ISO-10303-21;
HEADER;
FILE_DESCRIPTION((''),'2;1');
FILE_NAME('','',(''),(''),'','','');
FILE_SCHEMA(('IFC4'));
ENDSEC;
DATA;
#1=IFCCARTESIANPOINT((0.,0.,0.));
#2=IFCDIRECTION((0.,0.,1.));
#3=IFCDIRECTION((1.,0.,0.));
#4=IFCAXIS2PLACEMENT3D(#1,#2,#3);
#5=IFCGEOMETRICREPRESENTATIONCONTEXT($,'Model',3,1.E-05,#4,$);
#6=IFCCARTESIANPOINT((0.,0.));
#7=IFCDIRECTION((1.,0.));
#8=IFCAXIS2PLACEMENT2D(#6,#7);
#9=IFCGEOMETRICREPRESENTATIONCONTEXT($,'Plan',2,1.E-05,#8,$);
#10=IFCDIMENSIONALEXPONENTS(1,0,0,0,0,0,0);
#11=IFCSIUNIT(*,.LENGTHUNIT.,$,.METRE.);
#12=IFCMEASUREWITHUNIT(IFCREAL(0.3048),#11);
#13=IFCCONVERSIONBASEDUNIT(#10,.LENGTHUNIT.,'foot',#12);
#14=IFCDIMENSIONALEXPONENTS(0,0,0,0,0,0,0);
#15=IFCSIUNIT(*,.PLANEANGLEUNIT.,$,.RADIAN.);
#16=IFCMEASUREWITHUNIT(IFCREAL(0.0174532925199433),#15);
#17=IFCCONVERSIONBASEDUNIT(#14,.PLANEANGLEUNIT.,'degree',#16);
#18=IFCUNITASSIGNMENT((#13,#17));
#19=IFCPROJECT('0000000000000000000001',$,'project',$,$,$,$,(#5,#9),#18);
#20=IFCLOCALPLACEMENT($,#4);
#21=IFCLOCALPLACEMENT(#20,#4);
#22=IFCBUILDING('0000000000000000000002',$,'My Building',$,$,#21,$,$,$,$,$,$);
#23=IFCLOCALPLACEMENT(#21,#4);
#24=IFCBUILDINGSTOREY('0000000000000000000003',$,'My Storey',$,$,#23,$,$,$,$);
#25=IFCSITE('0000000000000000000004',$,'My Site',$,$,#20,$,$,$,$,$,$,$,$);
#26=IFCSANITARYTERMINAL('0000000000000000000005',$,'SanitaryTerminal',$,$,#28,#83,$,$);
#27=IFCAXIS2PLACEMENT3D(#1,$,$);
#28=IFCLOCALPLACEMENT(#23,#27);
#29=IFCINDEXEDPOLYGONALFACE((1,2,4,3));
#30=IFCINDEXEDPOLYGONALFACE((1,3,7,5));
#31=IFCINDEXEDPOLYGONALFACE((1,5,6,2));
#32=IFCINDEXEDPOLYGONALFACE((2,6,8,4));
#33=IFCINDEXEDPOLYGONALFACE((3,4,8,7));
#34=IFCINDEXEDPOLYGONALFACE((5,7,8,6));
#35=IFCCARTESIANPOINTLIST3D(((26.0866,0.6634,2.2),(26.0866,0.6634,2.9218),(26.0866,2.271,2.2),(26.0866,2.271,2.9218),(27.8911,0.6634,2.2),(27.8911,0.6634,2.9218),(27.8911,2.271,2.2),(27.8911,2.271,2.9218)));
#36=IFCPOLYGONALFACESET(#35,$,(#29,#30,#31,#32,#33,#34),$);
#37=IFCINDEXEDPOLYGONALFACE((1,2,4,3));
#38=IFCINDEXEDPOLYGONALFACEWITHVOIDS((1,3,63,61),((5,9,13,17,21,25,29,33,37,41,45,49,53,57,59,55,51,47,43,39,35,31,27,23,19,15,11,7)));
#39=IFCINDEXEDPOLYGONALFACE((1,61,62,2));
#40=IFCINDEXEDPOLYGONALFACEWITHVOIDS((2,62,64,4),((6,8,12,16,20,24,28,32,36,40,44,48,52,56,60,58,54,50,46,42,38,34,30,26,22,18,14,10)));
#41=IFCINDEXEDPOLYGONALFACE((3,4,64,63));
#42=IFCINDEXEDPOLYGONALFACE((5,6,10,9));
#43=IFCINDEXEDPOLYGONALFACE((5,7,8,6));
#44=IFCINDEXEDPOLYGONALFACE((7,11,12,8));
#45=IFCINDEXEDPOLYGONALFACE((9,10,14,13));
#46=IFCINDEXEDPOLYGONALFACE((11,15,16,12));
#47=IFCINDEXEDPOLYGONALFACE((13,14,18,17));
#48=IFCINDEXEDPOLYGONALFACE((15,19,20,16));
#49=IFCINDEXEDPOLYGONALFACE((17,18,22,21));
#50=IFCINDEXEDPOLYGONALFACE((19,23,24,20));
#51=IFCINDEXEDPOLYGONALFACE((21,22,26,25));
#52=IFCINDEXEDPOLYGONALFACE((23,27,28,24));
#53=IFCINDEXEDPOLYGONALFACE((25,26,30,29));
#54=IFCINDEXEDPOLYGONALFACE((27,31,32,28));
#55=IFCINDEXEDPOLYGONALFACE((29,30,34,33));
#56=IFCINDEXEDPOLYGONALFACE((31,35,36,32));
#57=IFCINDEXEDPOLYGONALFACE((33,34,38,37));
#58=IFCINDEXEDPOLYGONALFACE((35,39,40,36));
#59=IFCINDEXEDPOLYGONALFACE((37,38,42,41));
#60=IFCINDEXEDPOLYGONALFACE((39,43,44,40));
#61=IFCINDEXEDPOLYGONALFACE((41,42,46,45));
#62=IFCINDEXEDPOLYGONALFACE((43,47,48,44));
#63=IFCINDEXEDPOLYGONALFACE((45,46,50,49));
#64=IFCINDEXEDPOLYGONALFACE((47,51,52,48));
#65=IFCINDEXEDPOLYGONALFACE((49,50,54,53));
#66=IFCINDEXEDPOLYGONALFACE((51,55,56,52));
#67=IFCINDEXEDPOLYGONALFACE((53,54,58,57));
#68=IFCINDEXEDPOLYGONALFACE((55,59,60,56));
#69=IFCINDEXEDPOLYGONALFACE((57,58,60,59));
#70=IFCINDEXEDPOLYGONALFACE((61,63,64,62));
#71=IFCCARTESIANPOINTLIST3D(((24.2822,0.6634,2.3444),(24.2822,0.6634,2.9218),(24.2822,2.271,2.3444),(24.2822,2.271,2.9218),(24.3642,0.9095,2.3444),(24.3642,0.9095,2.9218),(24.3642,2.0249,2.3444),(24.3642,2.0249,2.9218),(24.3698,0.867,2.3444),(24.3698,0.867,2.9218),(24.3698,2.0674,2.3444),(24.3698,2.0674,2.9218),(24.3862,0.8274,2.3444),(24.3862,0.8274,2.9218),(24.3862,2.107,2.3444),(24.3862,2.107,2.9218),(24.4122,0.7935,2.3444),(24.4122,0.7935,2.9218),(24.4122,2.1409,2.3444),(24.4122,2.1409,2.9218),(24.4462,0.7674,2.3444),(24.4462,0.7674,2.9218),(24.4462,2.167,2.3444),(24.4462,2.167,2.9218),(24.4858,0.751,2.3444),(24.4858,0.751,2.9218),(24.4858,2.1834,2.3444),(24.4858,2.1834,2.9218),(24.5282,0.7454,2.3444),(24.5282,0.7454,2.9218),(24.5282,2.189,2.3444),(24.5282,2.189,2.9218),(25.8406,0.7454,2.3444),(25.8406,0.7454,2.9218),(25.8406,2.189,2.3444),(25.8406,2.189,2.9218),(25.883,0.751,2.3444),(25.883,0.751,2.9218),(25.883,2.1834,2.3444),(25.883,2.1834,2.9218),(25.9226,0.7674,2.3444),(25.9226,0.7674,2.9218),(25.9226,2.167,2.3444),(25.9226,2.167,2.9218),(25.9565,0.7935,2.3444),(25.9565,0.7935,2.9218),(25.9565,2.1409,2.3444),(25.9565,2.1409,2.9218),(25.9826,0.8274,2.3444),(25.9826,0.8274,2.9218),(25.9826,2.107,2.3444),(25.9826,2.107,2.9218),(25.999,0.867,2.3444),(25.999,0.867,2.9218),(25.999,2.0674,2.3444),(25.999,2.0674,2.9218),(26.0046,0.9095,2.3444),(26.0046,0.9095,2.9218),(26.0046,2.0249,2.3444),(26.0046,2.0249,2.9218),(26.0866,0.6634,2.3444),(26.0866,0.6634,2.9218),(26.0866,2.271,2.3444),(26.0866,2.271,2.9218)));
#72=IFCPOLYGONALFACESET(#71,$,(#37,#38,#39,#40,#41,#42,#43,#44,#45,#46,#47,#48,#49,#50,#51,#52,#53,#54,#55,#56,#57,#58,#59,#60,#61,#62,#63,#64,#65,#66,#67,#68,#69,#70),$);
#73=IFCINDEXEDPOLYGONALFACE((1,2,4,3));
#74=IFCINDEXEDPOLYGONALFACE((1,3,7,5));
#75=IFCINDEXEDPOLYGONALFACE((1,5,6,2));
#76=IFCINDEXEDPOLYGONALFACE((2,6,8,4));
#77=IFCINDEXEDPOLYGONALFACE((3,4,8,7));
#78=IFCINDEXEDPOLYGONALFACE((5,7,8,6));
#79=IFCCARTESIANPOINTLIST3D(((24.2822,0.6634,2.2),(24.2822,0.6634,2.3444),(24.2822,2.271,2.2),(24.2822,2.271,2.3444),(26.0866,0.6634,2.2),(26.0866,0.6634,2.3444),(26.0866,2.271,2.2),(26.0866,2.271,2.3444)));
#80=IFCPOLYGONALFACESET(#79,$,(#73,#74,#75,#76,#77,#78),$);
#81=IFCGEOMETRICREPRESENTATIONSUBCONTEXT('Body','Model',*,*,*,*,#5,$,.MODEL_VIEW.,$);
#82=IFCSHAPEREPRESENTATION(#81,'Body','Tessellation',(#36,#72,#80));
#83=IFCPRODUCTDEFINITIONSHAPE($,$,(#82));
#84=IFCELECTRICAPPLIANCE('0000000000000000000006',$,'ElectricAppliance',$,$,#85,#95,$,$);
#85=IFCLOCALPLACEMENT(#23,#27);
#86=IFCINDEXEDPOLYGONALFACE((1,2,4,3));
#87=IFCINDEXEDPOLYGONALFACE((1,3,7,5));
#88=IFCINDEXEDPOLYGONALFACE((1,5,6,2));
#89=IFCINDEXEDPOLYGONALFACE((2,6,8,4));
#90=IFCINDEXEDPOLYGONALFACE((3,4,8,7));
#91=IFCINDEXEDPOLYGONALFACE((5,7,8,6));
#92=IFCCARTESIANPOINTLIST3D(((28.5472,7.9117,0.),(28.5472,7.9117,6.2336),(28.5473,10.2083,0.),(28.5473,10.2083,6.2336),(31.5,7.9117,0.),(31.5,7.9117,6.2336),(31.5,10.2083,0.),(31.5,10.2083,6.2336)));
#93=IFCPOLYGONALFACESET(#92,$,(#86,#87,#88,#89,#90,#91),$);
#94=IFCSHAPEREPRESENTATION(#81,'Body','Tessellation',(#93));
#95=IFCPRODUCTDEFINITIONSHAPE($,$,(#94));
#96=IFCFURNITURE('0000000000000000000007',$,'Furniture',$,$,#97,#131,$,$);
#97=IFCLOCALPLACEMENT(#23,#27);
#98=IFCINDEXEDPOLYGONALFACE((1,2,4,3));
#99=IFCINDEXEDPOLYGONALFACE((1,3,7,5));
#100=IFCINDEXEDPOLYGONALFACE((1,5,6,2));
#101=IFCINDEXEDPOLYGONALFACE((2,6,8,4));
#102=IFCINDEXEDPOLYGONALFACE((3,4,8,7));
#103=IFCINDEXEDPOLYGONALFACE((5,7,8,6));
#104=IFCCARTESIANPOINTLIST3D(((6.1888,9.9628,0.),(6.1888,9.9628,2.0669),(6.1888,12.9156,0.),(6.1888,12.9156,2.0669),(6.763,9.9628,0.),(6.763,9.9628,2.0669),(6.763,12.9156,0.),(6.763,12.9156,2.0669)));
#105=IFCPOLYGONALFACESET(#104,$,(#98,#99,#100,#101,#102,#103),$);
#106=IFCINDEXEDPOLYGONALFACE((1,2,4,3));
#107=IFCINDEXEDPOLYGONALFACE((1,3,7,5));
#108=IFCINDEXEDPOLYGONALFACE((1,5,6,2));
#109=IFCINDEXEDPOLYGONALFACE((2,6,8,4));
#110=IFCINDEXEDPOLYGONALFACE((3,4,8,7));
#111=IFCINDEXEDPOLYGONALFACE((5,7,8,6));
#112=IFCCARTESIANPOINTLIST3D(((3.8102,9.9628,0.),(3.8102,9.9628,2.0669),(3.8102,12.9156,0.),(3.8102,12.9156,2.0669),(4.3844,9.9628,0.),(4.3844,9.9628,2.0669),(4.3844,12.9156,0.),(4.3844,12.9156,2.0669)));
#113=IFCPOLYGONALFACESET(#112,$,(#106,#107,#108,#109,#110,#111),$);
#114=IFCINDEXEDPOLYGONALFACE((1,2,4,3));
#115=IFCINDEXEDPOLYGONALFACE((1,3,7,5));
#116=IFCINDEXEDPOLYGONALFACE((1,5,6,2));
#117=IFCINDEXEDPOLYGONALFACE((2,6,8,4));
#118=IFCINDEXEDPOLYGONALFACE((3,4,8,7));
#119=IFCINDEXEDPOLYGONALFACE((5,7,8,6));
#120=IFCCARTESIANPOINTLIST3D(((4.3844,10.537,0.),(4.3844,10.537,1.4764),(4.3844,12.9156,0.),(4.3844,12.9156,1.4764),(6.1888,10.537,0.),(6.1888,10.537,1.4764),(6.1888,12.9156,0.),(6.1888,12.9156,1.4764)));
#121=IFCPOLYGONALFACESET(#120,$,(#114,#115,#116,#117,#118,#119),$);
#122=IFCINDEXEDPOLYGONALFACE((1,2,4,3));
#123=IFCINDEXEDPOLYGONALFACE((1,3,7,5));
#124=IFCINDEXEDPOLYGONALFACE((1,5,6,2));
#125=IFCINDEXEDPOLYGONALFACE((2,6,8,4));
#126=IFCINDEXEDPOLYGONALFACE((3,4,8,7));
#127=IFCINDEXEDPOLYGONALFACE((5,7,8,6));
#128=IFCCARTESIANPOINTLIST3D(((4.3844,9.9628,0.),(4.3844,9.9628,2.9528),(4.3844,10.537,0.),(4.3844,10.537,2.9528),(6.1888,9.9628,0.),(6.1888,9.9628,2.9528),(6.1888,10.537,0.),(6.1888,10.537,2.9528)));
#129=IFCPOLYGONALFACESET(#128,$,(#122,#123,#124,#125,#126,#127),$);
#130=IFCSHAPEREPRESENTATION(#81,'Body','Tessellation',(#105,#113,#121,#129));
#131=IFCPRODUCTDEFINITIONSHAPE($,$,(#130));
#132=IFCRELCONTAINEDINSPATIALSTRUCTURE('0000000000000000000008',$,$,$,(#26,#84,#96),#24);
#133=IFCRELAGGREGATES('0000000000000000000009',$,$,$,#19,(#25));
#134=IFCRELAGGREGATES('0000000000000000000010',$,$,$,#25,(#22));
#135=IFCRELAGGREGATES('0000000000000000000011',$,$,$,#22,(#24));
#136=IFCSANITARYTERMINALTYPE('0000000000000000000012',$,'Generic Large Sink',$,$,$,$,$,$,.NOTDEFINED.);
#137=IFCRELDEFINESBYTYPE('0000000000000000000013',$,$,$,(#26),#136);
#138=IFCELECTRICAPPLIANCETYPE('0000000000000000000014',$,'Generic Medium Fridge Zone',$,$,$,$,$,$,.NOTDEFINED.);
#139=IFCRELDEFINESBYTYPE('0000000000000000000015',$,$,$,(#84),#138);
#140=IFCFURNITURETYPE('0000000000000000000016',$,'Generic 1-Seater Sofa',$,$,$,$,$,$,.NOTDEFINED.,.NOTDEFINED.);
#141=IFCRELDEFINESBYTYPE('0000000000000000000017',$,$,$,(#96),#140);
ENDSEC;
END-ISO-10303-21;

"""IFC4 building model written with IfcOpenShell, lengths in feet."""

from ifc_helpers import new_model, entity, si_unit, converted_unit, frame, origin_with_axes, origin_2d_with_axis, place, context, subcontext, project, spatial, line, indexed_curve, outline, extrude, shape, source, transform, mapped, type_object, type_shapes, element, save


model = new_model("IFC4")

# Units and contexts
model_context = context("Model", 3, precision=1e-05, world=origin_with_axes())
plan_context = context("Plan", 2, precision=1e-05, world=origin_2d_with_axis())
body_context_1 = subcontext(model_context, "Body", "Model", "MODEL_VIEW")
body_context_2 = subcontext(plan_context, "Body", "Plan", "PLAN_VIEW")
ifc_project = project(units=[converted_unit("LENGTHUNIT", "foot", entity("IfcReal", 0.3048), si_unit("LENGTHUNIT", "METRE"), dimensions=[1, 0, 0, 0, 0, 0, 0]), converted_unit("PLANEANGLEUNIT", "degree", entity("IfcReal", 0.0174532925199433), si_unit("PLANEANGLEUNIT", "RADIAN"), dimensions=[0, 0, 0, 0, 0, 0, 0])], contexts=[model_context, plan_context])

# Site, building, storey
site_placement = place(None, origin_with_axes())
site = spatial("IfcSite", under=ifc_project, at=site_placement, Name="My Site")
building_placement = place(site_placement, origin_with_axes())
building = spatial("IfcBuilding", under=site, at=building_placement, Name="My Building")
storey_placement = place(building_placement, origin_with_axes())
storey = spatial("IfcBuildingStorey", under=building, at=storey_placement, Name="My Storey")

# Sanitary terminal
sanitary_terminal_type_1 = type_object("IfcSanitaryTerminalType", Name="Generic Large Sink", PredefinedType="NOTDEFINED")
shared_indexed_poly_curve_1 = entity("IfcIndexedPolyCurve", entity("IfcCartesianPointList2D", [[1.8045, 0.0], [3.6089, 0.0], [3.6089, 1.6076], [1.8045, 1.6076]]), [entity("IfcLineIndex", [1, 2, 3, 4, 1])])
shared_shape_1 = source(origin_with_axes(), body_context_1, "Body", "SweptSolid", [
    extrude(outline(indexed_curve([(0.0, 0.0), (1.8045, 0.0), (1.8045, 1.6076), (0.0, 1.6076)], segments=[line(1, 2, 3, 4, 1)])), frame((-1.8045, -1.6076, 0.0), z_axis=(0.0, 0.0, 1.0), x_axis=(1.0, 0.0, 0.0)), (0.0, 0.0, 1.0), 0.7218),
    entity("IfcExtrudedAreaSolid", entity("IfcArbitraryProfileDefWithVoids", "AREA", None, shared_indexed_poly_curve_1, [entity("IfcIndexedPolyCurve", entity("IfcCartesianPointList2D", [[1.8865, 0.2461], [1.9345, 0.1301], [2.0505, 0.082], [3.3629, 0.082], [3.4789, 0.1301], [3.5269, 0.2461], [3.5269, 1.3615], [3.4789, 1.4775], [3.3629, 1.5256], [2.0505, 1.5256], [1.9345, 1.4775], [1.8865, 1.3615]]), [entity("IfcLineIndex", [12, 1]), entity("IfcArcIndex", [1, 2, 3]), entity("IfcLineIndex", [3, 4]), entity("IfcArcIndex", [4, 5, 6]), entity("IfcLineIndex", [6, 7]), entity("IfcArcIndex", [7, 8, 9]), entity("IfcLineIndex", [9, 10]), entity("IfcArcIndex", [10, 11, 12]), entity("IfcLineIndex", [12, 1])])]), entity("IfcAxis2Placement3D", entity("IfcCartesianPoint", [-1.8045, -1.6076, 0.1444]), entity("IfcDirection", [0.0, 0.0, 1.0]), entity("IfcDirection", [1.0, 0.0, 0.0])), entity("IfcDirection", [0.0, 0.0, 1.0]), 0.5774),
    entity("IfcExtrudedAreaSolid", entity("IfcArbitraryClosedProfileDef", "AREA", None, shared_indexed_poly_curve_1), entity("IfcAxis2Placement3D", entity("IfcCartesianPoint", [-1.8045, -1.6076, 0.0]), entity("IfcDirection", [0.0, 0.0, 1.0]), entity("IfcDirection", [1.0, 0.0, 0.0])), entity("IfcDirection", [0.0, 0.0, 1.0]), 0.1444),
])
shared_shape_2 = source(origin_with_axes(), body_context_2, "Body", "Curve2D", [
    entity("IfcIndexedPolyCurve", entity("IfcCartesianPointList2D", [[-1.8045, -1.6076], [1.8045, -1.6076], [1.8045, 0.0], [-1.8045, 0.0]]), [entity("IfcLineIndex", [1, 2, 3, 4, 1])]),
    entity("IfcIndexedPolyCurve", entity("IfcCartesianPointList2D", [[0.082, -1.3615], [0.1301, -1.4775], [0.2461, -1.5256], [1.5584, -1.5256], [1.6744, -1.4775], [1.7224, -1.3615], [1.7224, -0.2461], [1.6744, -0.1301], [1.5584, -0.082], [0.2461, -0.082], [0.1301, -0.1301], [0.082, -0.2461]]), [entity("IfcLineIndex", [12, 1]), entity("IfcArcIndex", [1, 2, 3]), entity("IfcLineIndex", [3, 4]), entity("IfcArcIndex", [4, 5, 6]), entity("IfcLineIndex", [6, 7]), entity("IfcArcIndex", [7, 8, 9]), entity("IfcLineIndex", [9, 10]), entity("IfcArcIndex", [10, 11, 12]), entity("IfcLineIndex", [12, 1])]),
    entity("IfcCircle", entity("IfcAxis2Placement2D", entity("IfcCartesianPoint", [0.9022, -0.4101])), 0.082),
    entity("IfcIndexedPolyCurve", entity("IfcCartesianPointList2D", [[0.9022, -0.041], [0.9022, -0.4347]])),
])
type_shapes(sanitary_terminal_type_1, [shared_shape_1, shared_shape_2])
sanitary_terminal_1_placement = place(storey_placement, frame((26.0866, 0.6634, 2.2), z_axis=(0.0, 0.0, 1.0), x_axis=(-1.0, 0.0, 0.0)))
element("IfcSanitaryTerminal", 1, at=sanitary_terminal_1_placement, inside=storey, type_object=sanitary_terminal_type_1, Name="SanitaryTerminal", shapes=[
    shape(body_context_1, "Body", "MappedRepresentation", [mapped(shared_shape_1, transform((0.0, 0.0, 0.0), x_axis=(1.0, 0.0, 0.0), y_axis=(0.0, 1.0, 0.0), z_axis=(0.0, 0.0, 1.0), scale=1.0))]),
    shape(body_context_2, "Body", "MappedRepresentation", [mapped(shared_shape_2, transform((0.0, 0.0, 0.0), x_axis=(1.0, 0.0, 0.0), y_axis=(0.0, 1.0, 0.0), z_axis=(0.0, 0.0, 1.0), scale=1.0))]),
])

# Electric appliance
electric_appliance_type_1 = type_object("IfcElectricApplianceType", Name="Generic Medium Fridge Zone", PredefinedType="NOTDEFINED")
shared_shape_3 = source(origin_with_axes(), body_context_1, "Body", "SweptSolid", [
    extrude(outline(indexed_curve([(0.0, 0.0), (2.9528, 0.0), (2.9528, 2.2966), (0.0, 2.2966)], segments=[line(1, 2, 3, 4, 1)])), origin_with_axes(), (0.0, 0.0, 1.0), 6.2336),
])
shared_shape_4 = source(origin_with_axes(), body_context_2, "Body", "Curve2D", [
    entity("IfcIndexedPolyCurve", entity("IfcCartesianPointList2D", [[0.0, 0.0], [2.9528, 0.0], [2.9528, 2.2966], [0.0, 2.2966]]), [entity("IfcLineIndex", [1, 2, 3, 4, 1])]),
])
type_shapes(electric_appliance_type_1, [shared_shape_3, shared_shape_4])
electric_appliance_1_placement = place(storey_placement, frame((31.5, 10.2083, 0.0), z_axis=(0.0, 0.0, 1.0), x_axis=(-1.0, 0.0, 0.0)))
element("IfcElectricAppliance", 2, at=electric_appliance_1_placement, inside=storey, type_object=electric_appliance_type_1, Name="ElectricAppliance", shapes=[
    shape(body_context_1, "Body", "MappedRepresentation", [mapped(shared_shape_3, transform((0.0, 0.0, 0.0), x_axis=(1.0, 0.0, 0.0), y_axis=(0.0, 1.0, 0.0), z_axis=(0.0, 0.0, 1.0), scale=1.0))]),
    shape(body_context_2, "Body", "MappedRepresentation", [mapped(shared_shape_4, transform((0.0, 0.0, 0.0), x_axis=(1.0, 0.0, 0.0), y_axis=(0.0, 1.0, 0.0), z_axis=(0.0, 0.0, 1.0), scale=1.0))]),
])

# Furniture
furniture_type_1 = type_object("IfcFurnitureType", Name="Generic 1-Seater Sofa", AssemblyPlace="NOTDEFINED", PredefinedType="NOTDEFINED")
shared_shape_5 = source(origin_with_axes(), body_context_1, "Body", "SweptSolid", [
    extrude(outline(indexed_curve([(0.0, 0.0), (0.5741, 0.0), (0.5741, 2.9528), (0.0, 2.9528)], segments=[line(1, 2, 3, 4, 1)])), frame((-1.4764, -2.9528, 0.0), z_axis=(0.0, 0.0, 1.0), x_axis=(1.0, 0.0, 0.0)), (0.0, 0.0, 1.0), 2.0669),
    extrude(outline(indexed_curve([(0.0, 0.0), (0.5741, 0.0), (0.5741, 2.9528), (0.0, 2.9528)], segments=[line(1, 2, 3, 4, 1)])), frame((0.9022, -2.9528, 0.0), z_axis=(0.0, 0.0, 1.0), x_axis=(1.0, 0.0, 0.0)), (0.0, 0.0, 1.0), 2.0669),
    extrude(outline(indexed_curve([(0.5741, 0.0), (2.3786, 0.0), (2.3786, 2.3786), (0.5741, 2.3786)], segments=[line(1, 2, 3, 4, 1)])), frame((-1.4764, -2.9528, 0.0), z_axis=(0.0, 0.0, 1.0), x_axis=(1.0, 0.0, 0.0)), (0.0, 0.0, 1.0), 1.4764),
    extrude(outline(indexed_curve([(0.5741, 2.3786), (2.3786, 2.3786), (2.3786, 2.9528), (0.5741, 2.9528)], segments=[line(1, 2, 3, 4, 1)])), frame((-1.4764, -2.9528, 0.0), z_axis=(0.0, 0.0, 1.0), x_axis=(1.0, 0.0, 0.0)), (0.0, 0.0, 1.0), 2.9528),
])
shared_shape_6 = source(origin_with_axes(), body_context_2, "Body", "Curve2D", [
    entity("IfcIndexedPolyCurve", entity("IfcCartesianPointList2D", [[-1.4764, -2.9528], [-0.9022, -2.9528], [-0.9022, 0.0], [-1.4764, 0.0]]), [entity("IfcLineIndex", [1, 2, 3, 4, 1])]),
    entity("IfcIndexedPolyCurve", entity("IfcCartesianPointList2D", [[0.9022, -2.9528], [1.4764, -2.9528], [1.4764, 0.0], [0.9022, 0.0]]), [entity("IfcLineIndex", [1, 2, 3, 4, 1])]),
    entity("IfcIndexedPolyCurve", entity("IfcCartesianPointList2D", [[-0.9022, -2.9528], [0.9022, -2.9528], [0.9022, -0.5741], [-0.9022, -0.5741]]), [entity("IfcLineIndex", [1, 2, 3, 4, 1])]),
    entity("IfcIndexedPolyCurve", entity("IfcCartesianPointList2D", [[-0.9022, -0.5741], [0.9022, -0.5741], [0.9022, 0.0], [-0.9022, 0.0]]), [entity("IfcLineIndex", [1, 2, 3, 4, 1])]),
])
type_shapes(furniture_type_1, [shared_shape_5, shared_shape_6])
furniture_1_placement = place(storey_placement, frame((5.2866, 9.9628, 0.0), z_axis=(0.0, 0.0, 1.0), x_axis=(-1.0, 0.0, 0.0)))
element("IfcFurniture", 3, at=furniture_1_placement, inside=storey, type_object=furniture_type_1, Name="Furniture", shapes=[
    shape(body_context_1, "Body", "MappedRepresentation", [mapped(shared_shape_5, transform((0.0, 0.0, 0.0), x_axis=(1.0, 0.0, 0.0), y_axis=(0.0, 1.0, 0.0), z_axis=(0.0, 0.0, 1.0), scale=1.0))]),
    shape(body_context_2, "Body", "MappedRepresentation", [mapped(shared_shape_6, transform((0.0, 0.0, 0.0), x_axis=(1.0, 0.0, 0.0), y_axis=(0.0, 1.0, 0.0), z_axis=(0.0, 0.0, 1.0), scale=1.0))]),
])

save(model, "model.ifc")
